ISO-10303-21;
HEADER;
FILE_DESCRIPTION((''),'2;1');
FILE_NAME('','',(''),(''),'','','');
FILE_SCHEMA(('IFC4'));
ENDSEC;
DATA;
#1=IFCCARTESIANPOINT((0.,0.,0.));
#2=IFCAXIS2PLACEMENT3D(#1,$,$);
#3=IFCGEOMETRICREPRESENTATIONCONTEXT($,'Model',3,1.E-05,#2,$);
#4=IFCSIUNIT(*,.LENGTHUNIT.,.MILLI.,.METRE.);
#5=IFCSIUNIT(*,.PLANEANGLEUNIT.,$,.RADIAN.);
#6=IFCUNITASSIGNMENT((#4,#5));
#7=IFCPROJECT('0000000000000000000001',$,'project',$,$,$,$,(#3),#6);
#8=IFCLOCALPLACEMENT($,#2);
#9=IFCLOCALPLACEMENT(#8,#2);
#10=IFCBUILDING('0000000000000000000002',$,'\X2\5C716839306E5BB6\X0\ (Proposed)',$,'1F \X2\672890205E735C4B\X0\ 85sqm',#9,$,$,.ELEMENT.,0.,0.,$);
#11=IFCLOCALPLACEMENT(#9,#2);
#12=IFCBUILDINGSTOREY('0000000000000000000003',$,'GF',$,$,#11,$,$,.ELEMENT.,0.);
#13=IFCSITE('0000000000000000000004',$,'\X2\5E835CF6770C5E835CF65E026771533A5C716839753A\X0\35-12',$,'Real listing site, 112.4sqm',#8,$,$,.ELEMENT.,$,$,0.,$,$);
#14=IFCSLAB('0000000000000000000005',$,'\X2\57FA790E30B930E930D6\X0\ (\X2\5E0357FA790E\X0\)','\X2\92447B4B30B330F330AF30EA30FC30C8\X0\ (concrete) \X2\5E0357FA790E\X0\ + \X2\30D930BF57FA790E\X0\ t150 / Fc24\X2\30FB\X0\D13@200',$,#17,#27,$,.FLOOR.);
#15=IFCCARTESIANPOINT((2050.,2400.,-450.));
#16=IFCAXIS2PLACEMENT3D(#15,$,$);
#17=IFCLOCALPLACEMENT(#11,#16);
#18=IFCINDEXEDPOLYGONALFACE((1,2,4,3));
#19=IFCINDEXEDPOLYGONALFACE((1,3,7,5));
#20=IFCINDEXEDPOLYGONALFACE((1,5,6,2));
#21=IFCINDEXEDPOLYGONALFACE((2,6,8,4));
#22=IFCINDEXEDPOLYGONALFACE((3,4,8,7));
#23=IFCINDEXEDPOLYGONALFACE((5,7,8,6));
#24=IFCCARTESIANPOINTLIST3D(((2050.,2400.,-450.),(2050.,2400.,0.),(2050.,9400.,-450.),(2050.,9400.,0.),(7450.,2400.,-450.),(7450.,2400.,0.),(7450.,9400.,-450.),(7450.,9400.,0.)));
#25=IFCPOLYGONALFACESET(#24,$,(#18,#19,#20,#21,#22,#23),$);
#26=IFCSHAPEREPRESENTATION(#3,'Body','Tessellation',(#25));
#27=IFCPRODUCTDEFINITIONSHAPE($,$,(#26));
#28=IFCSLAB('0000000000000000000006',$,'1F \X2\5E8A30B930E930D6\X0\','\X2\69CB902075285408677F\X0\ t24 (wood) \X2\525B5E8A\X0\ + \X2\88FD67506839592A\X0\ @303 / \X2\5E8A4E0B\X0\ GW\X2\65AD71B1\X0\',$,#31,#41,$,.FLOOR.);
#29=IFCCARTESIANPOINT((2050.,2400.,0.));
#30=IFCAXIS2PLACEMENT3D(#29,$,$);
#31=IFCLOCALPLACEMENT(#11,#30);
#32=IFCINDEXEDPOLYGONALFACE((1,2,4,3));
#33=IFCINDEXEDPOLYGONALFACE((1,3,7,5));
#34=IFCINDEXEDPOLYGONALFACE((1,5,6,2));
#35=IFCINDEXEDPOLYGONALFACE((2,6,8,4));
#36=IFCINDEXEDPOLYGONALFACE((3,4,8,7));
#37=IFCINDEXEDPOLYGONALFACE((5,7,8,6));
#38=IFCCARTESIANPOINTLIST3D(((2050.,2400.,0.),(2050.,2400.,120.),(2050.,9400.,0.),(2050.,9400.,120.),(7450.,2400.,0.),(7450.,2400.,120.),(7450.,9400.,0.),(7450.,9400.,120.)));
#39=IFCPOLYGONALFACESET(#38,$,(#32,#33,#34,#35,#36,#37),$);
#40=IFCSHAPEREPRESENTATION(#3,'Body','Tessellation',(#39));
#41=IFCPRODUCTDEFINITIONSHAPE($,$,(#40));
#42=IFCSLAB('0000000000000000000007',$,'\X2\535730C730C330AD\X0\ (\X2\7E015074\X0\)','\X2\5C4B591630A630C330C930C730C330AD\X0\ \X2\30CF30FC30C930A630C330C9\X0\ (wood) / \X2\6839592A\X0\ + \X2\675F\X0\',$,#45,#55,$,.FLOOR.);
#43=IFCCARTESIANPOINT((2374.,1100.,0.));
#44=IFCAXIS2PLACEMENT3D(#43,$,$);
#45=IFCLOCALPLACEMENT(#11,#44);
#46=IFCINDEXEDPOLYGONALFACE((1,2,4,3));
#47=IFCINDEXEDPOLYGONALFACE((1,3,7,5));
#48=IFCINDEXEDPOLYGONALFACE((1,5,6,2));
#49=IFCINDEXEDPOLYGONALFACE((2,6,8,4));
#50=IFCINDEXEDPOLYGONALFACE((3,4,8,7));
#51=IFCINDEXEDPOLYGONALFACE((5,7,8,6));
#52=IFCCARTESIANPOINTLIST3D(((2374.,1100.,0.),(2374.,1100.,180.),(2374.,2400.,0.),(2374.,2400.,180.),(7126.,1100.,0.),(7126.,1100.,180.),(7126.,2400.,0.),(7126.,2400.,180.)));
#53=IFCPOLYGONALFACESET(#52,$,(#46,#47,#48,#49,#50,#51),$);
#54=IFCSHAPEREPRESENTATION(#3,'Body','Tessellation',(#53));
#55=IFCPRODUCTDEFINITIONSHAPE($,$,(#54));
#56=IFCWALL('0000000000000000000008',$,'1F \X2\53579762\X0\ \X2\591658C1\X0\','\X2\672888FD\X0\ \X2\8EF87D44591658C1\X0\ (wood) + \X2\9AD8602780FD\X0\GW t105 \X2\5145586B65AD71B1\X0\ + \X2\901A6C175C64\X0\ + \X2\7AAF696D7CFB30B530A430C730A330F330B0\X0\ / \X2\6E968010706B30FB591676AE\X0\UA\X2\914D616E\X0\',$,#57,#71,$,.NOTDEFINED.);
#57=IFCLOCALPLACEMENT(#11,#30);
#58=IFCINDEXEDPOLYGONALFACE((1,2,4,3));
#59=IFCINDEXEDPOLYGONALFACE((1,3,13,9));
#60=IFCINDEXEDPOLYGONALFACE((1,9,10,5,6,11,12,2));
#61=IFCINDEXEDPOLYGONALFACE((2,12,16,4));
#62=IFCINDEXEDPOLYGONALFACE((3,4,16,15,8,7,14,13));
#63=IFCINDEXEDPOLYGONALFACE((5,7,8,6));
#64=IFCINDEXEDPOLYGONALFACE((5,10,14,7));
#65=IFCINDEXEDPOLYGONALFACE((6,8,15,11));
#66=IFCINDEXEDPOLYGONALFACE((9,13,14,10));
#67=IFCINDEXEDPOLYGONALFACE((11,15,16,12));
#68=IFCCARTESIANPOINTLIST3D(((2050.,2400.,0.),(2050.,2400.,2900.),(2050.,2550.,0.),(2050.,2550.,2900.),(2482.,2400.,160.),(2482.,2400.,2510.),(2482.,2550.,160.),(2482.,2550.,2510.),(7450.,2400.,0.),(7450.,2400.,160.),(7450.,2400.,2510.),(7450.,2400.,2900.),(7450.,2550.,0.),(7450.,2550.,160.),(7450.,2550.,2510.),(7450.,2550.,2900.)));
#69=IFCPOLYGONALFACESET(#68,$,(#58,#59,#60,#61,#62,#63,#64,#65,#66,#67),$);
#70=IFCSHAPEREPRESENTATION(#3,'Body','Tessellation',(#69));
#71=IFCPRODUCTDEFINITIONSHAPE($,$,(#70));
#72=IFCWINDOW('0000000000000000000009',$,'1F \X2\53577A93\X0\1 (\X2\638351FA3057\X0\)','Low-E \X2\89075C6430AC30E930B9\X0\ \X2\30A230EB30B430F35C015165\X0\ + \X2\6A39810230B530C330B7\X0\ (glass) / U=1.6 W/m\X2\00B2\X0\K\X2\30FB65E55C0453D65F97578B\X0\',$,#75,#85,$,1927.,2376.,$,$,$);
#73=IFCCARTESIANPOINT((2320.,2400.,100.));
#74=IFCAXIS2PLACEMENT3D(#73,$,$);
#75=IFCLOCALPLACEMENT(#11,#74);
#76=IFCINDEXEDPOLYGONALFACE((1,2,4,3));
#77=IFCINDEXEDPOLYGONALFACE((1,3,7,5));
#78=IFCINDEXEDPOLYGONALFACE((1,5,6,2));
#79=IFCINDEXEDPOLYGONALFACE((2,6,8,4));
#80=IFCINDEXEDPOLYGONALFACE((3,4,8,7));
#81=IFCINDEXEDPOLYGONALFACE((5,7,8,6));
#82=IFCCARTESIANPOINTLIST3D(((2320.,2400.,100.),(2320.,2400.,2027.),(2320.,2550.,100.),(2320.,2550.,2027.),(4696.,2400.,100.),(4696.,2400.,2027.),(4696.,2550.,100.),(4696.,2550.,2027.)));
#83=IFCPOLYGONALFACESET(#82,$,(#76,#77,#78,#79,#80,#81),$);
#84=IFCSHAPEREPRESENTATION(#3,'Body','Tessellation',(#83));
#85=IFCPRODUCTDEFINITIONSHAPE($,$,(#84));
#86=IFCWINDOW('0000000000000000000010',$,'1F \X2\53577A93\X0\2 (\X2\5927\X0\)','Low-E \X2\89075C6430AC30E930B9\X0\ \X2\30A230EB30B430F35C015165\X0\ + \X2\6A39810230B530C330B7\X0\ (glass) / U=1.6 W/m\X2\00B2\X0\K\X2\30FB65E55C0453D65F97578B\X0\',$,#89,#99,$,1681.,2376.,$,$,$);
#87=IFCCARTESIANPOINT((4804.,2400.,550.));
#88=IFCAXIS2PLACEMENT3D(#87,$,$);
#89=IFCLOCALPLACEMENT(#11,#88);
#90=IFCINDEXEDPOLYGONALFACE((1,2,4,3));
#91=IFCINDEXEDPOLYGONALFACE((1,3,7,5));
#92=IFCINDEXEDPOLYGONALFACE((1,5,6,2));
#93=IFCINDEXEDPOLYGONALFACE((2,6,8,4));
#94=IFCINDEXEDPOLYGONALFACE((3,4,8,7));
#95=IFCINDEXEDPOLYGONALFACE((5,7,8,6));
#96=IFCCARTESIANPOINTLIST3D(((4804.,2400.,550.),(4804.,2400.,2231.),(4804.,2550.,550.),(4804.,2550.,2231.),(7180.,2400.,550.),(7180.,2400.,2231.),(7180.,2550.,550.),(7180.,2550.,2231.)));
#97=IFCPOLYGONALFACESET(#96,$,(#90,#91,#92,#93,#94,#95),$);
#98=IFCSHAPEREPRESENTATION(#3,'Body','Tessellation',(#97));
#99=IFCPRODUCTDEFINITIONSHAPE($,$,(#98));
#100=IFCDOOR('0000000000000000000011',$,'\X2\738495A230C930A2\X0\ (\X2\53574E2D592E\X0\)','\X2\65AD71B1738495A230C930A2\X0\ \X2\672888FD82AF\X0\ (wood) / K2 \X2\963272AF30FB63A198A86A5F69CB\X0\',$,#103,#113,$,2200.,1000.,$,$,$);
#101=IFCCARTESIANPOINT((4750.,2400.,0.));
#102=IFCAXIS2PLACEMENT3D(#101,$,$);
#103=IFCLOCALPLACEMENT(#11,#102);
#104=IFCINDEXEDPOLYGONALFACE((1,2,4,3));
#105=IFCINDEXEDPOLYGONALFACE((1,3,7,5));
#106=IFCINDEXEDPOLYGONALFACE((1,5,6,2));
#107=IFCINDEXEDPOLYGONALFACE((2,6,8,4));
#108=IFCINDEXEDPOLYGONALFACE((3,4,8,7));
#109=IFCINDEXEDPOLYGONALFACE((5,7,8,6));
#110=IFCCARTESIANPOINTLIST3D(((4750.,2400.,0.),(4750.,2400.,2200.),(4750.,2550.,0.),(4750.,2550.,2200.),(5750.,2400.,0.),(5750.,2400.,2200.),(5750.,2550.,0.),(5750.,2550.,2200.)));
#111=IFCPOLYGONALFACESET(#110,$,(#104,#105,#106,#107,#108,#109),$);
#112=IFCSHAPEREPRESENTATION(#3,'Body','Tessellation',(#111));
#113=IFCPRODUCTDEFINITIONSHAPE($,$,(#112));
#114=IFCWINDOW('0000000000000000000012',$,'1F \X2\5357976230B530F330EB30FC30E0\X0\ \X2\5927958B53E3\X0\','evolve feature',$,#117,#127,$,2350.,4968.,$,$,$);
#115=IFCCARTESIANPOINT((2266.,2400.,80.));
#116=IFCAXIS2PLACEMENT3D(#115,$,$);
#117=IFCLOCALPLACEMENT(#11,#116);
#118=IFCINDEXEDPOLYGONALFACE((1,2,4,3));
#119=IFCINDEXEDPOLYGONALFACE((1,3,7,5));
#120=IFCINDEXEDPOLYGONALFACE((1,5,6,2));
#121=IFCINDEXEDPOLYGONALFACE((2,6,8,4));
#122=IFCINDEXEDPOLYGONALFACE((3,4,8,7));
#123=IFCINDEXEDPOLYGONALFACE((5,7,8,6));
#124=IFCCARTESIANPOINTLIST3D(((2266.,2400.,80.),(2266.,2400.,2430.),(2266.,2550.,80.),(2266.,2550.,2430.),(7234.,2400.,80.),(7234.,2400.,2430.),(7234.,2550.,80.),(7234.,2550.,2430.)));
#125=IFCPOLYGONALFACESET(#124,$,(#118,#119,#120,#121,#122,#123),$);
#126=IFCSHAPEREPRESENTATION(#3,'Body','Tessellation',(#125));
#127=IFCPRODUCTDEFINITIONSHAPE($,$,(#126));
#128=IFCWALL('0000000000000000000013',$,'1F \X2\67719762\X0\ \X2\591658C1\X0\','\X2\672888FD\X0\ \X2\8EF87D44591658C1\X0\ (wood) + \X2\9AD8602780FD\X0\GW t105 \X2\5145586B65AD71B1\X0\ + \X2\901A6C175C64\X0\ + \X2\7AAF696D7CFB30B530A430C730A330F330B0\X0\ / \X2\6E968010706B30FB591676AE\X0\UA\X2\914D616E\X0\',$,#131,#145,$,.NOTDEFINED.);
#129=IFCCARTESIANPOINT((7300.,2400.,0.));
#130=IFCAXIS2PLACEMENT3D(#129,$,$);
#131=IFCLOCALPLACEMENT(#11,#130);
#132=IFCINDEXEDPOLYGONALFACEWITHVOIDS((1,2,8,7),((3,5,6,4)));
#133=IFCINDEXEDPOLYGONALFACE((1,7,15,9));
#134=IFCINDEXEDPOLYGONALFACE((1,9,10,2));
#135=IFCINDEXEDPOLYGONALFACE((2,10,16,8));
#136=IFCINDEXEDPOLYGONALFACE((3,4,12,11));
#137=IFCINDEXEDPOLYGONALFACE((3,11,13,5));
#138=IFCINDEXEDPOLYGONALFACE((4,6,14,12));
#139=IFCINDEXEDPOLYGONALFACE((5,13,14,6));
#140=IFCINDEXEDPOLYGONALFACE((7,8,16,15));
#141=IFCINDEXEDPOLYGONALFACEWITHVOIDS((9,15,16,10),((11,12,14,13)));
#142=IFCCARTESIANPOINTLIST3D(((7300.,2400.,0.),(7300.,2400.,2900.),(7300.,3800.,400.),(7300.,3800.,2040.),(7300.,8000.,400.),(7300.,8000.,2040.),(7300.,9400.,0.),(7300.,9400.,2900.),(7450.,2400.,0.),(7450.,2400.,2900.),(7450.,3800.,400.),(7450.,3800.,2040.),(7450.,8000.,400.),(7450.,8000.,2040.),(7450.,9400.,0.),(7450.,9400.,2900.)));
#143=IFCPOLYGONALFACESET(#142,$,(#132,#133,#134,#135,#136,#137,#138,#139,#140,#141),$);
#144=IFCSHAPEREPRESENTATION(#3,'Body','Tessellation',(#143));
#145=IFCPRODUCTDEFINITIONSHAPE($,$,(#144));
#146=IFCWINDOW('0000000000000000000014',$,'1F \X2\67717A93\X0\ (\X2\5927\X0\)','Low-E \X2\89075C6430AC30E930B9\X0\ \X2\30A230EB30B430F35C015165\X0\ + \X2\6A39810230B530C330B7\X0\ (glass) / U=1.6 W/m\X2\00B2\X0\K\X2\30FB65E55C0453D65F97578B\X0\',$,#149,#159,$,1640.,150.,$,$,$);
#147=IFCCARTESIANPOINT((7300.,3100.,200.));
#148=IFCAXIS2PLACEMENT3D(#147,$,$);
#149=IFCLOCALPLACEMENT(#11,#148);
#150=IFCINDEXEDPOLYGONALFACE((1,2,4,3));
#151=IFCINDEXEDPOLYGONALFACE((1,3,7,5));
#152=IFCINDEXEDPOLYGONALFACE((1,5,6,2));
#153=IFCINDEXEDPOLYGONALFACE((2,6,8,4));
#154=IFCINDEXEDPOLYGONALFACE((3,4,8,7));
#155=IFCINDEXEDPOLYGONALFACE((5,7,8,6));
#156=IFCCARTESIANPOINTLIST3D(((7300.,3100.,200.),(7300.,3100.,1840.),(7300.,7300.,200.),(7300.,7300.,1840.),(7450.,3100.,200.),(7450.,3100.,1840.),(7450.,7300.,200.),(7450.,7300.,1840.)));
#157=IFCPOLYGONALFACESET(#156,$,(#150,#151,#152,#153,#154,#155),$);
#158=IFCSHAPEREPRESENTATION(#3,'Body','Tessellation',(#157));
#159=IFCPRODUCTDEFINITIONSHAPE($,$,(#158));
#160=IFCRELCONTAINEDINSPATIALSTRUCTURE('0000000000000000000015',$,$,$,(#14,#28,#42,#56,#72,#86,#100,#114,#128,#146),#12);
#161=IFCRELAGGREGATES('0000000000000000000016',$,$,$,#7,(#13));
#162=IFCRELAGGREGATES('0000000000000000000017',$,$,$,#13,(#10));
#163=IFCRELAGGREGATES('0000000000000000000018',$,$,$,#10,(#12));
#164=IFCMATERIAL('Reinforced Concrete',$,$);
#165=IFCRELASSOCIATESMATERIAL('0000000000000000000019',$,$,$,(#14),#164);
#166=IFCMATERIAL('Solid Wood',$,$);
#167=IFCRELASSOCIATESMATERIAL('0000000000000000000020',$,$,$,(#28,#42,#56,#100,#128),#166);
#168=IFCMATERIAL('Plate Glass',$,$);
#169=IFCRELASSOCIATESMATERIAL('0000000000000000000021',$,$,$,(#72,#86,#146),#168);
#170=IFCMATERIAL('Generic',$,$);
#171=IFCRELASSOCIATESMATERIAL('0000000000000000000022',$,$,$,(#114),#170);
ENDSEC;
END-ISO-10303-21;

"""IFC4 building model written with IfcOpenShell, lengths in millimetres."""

from ifc_helpers import new_model, si_unit, frame, frame_2d, origin, place, context, project, spatial, rectangle, extrude, material, element, fill, save


model = new_model("IFC4")

# Units and contexts
model_context = context("Model", 3, precision=1e-05, world=origin())
ifc_project = project(units=[si_unit("LENGTHUNIT", "METRE", prefix="MILLI"), si_unit("PLANEANGLEUNIT", "RADIAN")], contexts=[model_context])

# Site, building, storey
site_placement = place(None, origin())
site = spatial("IfcSite", under=ifc_project, at=site_placement, Name="広島県広島市東区山根町35-12", ObjectType="Real listing site, 112.4sqm", CompositionType="ELEMENT", RefElevation=0.0)
building_placement = place(site_placement, origin())
building = spatial("IfcBuilding", under=site, at=building_placement, Name="山根の家 (Proposed)", ObjectType="1F 木造平屋 85sqm", CompositionType="ELEMENT", ElevationOfRefHeight=0.0, ElevationOfTerrain=0.0)
storey_placement = place(building_placement, origin())
storey = spatial("IfcBuildingStorey", under=building, at=storey_placement, Name="GF", CompositionType="ELEMENT", Elevation=0.0)

# Slabs
ifc_material_1 = material(Name="Reinforced Concrete")
slab_1_placement = place(storey_placement, frame((2050.0, 2400.0, -450.0)))
element("IfcSlab", 1, at=slab_1_placement, inside=storey, material=ifc_material_1, Name="基礎スラブ (布基礎)", Description="鉄筋コンクリート (concrete) 布基礎 + ベタ基礎 t150 / Fc24・D13@200", PredefinedType="FLOOR", context=model_context, shape_type="SweptSolid", body=[
    extrude(rectangle(XDim=5400.0, YDim=7000.0, at=frame_2d((2700.0, 3500.0))), frame((2050.0, 2400.0, -450.0)), (0.0, 0.0, 1.0), 450.0),
])
ifc_material_2 = material(Name="Solid Wood")
slab_2_placement = place(storey_placement, frame((2050.0, 2400.0, 0.0)))
element("IfcSlab", 2, at=slab_2_placement, inside=storey, material=ifc_material_2, Name="1F 床スラブ", Description="構造用合板 t24 (wood) 剛床 + 製材根太 @303 / 床下 GW断熱", PredefinedType="FLOOR", context=model_context, shape_type="SweptSolid", body=[
    extrude(rectangle(XDim=5400.0, YDim=7000.0, at=frame_2d((2700.0, 3500.0))), frame((2050.0, 2400.0, 0.0)), (0.0, 0.0, 1.0), 120.0),
])
slab_3_placement = place(storey_placement, frame((2374.0, 1100.0, 0.0)))
element("IfcSlab", 3, at=slab_3_placement, inside=storey, material=ifc_material_2, Name="南デッキ (縁側)", Description="屋外ウッドデッキ ハードウッド (wood) / 根太 + 束", PredefinedType="FLOOR", context=model_context, shape_type="SweptSolid", body=[
    extrude(rectangle(XDim=4752.0, YDim=1300.0, at=frame_2d((2376.0, 650.0))), frame((2374.0, 1100.0, 0.0)), (0.0, 0.0, 1.0), 180.0),
])
ifc_material_3 = material(Name="Generic")

# Wall, openings, windows, door
wall_1_placement = place(storey_placement, frame((2050.0, 2400.0, 0.0)))
wall_1 = element("IfcWall", 4, at=wall_1_placement, inside=storey, material=ifc_material_2, Name="1F 南面 外壁", Description="木製 軸組外壁 (wood) + 高性能GW t105 充填断熱 + 通気層 + 窯業系サイディング / 準耐火・外皮UA配慮", PredefinedType="NOTDEFINED", context=model_context, shape_type="SweptSolid", body=[
    extrude(rectangle(XDim=5400.0, YDim=150.0, at=frame_2d((2700.0, 75.0))), frame((2050.0, 2400.0, 0.0)), (0.0, 0.0, 1.0), 2900.0),
])
opening_1_placement = place(storey_placement, frame((2320.0, 2400.0, 100.0)))
opening_1 = element("IfcOpeningElement", 5, at=opening_1_placement, cuts=wall_1, PredefinedType="NOTDEFINED", context=model_context, shape_type="SweptSolid", body=[
    extrude(rectangle(XDim=2376.0, YDim=150.0, at=frame_2d((1188.0, 75.0))), frame((2320.0, 2400.0, 100.0)), (0.0, 0.0, 1.0), 1927.0),
])
opening_2_placement = place(storey_placement, frame((4804.0, 2400.0, 550.0)))
opening_2 = element("IfcOpeningElement", 6, at=opening_2_placement, cuts=wall_1, PredefinedType="NOTDEFINED", context=model_context, shape_type="SweptSolid", body=[
    extrude(rectangle(XDim=2376.0, YDim=150.0, at=frame_2d((1188.0, 75.0))), frame((4804.0, 2400.0, 550.0)), (0.0, 0.0, 1.0), 1681.0),
])
opening_3_placement = place(storey_placement, frame((4750.0, 2400.0, 0.0)))
opening_3 = element("IfcOpeningElement", 7, at=opening_3_placement, cuts=wall_1, PredefinedType="NOTDEFINED", context=model_context, shape_type="SweptSolid", body=[
    extrude(rectangle(XDim=1000.0, YDim=150.0, at=frame_2d((500.0, 75.0))), frame((4750.0, 2400.0, 0.0)), (0.0, 0.0, 1.0), 2200.0),
])
opening_4_placement = place(storey_placement, frame((2266.0, 2400.0, 80.0)))
opening_4 = element("IfcOpeningElement", 8, at=opening_4_placement, cuts=wall_1, PredefinedType="NOTDEFINED", context=model_context, shape_type="SweptSolid", body=[
    extrude(rectangle(XDim=4968.0, YDim=150.0, at=frame_2d((2484.0, 75.0))), frame((2266.0, 2400.0, 80.0)), (0.0, 0.0, 1.0), 2350.0),
])
ifc_material_4 = material(Name="Plate Glass")
window_1_placement = place(storey_placement, frame((2320.0, 2400.0, 100.0)))
window_1 = element("IfcWindow", 9, at=window_1_placement, inside=storey, material=ifc_material_4, Name="1F 南窓1 (掃出し)", Description="Low-E 複層ガラス アルゴン封入 + 樹脂サッシ (glass) / U=1.6 W/m²K・日射取得型", OverallHeight=1927.0, OverallWidth=2376.0, context=model_context, shape_type="SweptSolid", body=[
    extrude(rectangle(XDim=2376.0, YDim=150.0, at=frame_2d((1188.0, 75.0))), frame((2320.0, 2400.0, 100.0)), (0.0, 0.0, 1.0), 1927.0),
])
fill(opening_1, window_1)
window_2_placement = place(storey_placement, frame((4804.0, 2400.0, 550.0)))
window_2 = element("IfcWindow", 10, at=window_2_placement, inside=storey, material=ifc_material_4, Name="1F 南窓2 (大)", Description="Low-E 複層ガラス アルゴン封入 + 樹脂サッシ (glass) / U=1.6 W/m²K・日射取得型", OverallHeight=1681.0, OverallWidth=2376.0, context=model_context, shape_type="SweptSolid", body=[
    extrude(rectangle(XDim=2376.0, YDim=150.0, at=frame_2d((1188.0, 75.0))), frame((4804.0, 2400.0, 550.0)), (0.0, 0.0, 1.0), 1681.0),
])
fill(opening_2, window_2)
door_placement = place(storey_placement, frame((4750.0, 2400.0, 0.0)))
door = element("IfcDoor", 11, at=door_placement, inside=storey, material=ifc_material_2, Name="玄関ドア (南中央)", Description="断熱玄関ドア 木製芯 (wood) / K2 防犯・採風機構", OverallHeight=2200.0, OverallWidth=1000.0, context=model_context, shape_type="SweptSolid", body=[
    extrude(rectangle(XDim=1000.0, YDim=150.0, at=frame_2d((500.0, 75.0))), frame((4750.0, 2400.0, 0.0)), (0.0, 0.0, 1.0), 2200.0),
])
fill(opening_3, door)
window_3_placement = place(storey_placement, frame((2266.0, 2400.0, 80.0)))
window_3 = element("IfcWindow", 12, at=window_3_placement, inside=storey, material=ifc_material_3, Name="1F 南面サンルーム 大開口", Description="evolve feature", OverallHeight=2350.0, OverallWidth=4968.0, context=model_context, shape_type="SweptSolid", body=[
    extrude(rectangle(XDim=4968.0, YDim=150.0, at=frame_2d((2484.0, 75.0))), frame((2266.0, 2400.0, 80.0)), (0.0, 0.0, 1.0), 2350.0),
])
fill(opening_4, window_3)

# Wall, opening, window
wall_2_placement = place(storey_placement, frame((7300.0, 2400.0, 0.0)))
wall_2 = element("IfcWall", 13, at=wall_2_placement, inside=storey, material=ifc_material_2, Name="1F 東面 外壁", Description="木製 軸組外壁 (wood) + 高性能GW t105 充填断熱 + 通気層 + 窯業系サイディング / 準耐火・外皮UA配慮", PredefinedType="NOTDEFINED", context=model_context, shape_type="SweptSolid", body=[
    extrude(rectangle(XDim=150.0, YDim=7000.0, at=frame_2d((75.0, 3500.0))), frame((7300.0, 2400.0, 0.0)), (0.0, 0.0, 1.0), 2900.0),
])
opening_5_placement = place(storey_placement, frame((7300.0, 3100.0, 200.0)))
opening_5 = element("IfcOpeningElement", 14, at=opening_5_placement, cuts=wall_2, PredefinedType="NOTDEFINED", context=model_context, shape_type="SweptSolid", body=[
    extrude(rectangle(XDim=150.0, YDim=4200.0, at=frame_2d((75.0, 2100.0))), frame((7300.0, 3100.0, 200.0)), (0.0, 0.0, 1.0), 1640.0),
])
window_4_placement = place(storey_placement, frame((7300.0, 3100.0, 200.0)))
window_4 = element("IfcWindow", 15, at=window_4_placement, inside=storey, material=ifc_material_4, Name="1F 東窓 (大)", Description="Low-E 複層ガラス アルゴン封入 + 樹脂サッシ (glass) / U=1.6 W/m²K・日射取得型", OverallHeight=1640.0, OverallWidth=150.0, context=model_context, shape_type="SweptSolid", body=[
    extrude(rectangle(XDim=150.0, YDim=4200.0, at=frame_2d((75.0, 2100.0))), frame((7300.0, 3100.0, 200.0)), (0.0, 0.0, 1.0), 1640.0),
])
fill(opening_5, window_4)

save(model, "model.ifc")
